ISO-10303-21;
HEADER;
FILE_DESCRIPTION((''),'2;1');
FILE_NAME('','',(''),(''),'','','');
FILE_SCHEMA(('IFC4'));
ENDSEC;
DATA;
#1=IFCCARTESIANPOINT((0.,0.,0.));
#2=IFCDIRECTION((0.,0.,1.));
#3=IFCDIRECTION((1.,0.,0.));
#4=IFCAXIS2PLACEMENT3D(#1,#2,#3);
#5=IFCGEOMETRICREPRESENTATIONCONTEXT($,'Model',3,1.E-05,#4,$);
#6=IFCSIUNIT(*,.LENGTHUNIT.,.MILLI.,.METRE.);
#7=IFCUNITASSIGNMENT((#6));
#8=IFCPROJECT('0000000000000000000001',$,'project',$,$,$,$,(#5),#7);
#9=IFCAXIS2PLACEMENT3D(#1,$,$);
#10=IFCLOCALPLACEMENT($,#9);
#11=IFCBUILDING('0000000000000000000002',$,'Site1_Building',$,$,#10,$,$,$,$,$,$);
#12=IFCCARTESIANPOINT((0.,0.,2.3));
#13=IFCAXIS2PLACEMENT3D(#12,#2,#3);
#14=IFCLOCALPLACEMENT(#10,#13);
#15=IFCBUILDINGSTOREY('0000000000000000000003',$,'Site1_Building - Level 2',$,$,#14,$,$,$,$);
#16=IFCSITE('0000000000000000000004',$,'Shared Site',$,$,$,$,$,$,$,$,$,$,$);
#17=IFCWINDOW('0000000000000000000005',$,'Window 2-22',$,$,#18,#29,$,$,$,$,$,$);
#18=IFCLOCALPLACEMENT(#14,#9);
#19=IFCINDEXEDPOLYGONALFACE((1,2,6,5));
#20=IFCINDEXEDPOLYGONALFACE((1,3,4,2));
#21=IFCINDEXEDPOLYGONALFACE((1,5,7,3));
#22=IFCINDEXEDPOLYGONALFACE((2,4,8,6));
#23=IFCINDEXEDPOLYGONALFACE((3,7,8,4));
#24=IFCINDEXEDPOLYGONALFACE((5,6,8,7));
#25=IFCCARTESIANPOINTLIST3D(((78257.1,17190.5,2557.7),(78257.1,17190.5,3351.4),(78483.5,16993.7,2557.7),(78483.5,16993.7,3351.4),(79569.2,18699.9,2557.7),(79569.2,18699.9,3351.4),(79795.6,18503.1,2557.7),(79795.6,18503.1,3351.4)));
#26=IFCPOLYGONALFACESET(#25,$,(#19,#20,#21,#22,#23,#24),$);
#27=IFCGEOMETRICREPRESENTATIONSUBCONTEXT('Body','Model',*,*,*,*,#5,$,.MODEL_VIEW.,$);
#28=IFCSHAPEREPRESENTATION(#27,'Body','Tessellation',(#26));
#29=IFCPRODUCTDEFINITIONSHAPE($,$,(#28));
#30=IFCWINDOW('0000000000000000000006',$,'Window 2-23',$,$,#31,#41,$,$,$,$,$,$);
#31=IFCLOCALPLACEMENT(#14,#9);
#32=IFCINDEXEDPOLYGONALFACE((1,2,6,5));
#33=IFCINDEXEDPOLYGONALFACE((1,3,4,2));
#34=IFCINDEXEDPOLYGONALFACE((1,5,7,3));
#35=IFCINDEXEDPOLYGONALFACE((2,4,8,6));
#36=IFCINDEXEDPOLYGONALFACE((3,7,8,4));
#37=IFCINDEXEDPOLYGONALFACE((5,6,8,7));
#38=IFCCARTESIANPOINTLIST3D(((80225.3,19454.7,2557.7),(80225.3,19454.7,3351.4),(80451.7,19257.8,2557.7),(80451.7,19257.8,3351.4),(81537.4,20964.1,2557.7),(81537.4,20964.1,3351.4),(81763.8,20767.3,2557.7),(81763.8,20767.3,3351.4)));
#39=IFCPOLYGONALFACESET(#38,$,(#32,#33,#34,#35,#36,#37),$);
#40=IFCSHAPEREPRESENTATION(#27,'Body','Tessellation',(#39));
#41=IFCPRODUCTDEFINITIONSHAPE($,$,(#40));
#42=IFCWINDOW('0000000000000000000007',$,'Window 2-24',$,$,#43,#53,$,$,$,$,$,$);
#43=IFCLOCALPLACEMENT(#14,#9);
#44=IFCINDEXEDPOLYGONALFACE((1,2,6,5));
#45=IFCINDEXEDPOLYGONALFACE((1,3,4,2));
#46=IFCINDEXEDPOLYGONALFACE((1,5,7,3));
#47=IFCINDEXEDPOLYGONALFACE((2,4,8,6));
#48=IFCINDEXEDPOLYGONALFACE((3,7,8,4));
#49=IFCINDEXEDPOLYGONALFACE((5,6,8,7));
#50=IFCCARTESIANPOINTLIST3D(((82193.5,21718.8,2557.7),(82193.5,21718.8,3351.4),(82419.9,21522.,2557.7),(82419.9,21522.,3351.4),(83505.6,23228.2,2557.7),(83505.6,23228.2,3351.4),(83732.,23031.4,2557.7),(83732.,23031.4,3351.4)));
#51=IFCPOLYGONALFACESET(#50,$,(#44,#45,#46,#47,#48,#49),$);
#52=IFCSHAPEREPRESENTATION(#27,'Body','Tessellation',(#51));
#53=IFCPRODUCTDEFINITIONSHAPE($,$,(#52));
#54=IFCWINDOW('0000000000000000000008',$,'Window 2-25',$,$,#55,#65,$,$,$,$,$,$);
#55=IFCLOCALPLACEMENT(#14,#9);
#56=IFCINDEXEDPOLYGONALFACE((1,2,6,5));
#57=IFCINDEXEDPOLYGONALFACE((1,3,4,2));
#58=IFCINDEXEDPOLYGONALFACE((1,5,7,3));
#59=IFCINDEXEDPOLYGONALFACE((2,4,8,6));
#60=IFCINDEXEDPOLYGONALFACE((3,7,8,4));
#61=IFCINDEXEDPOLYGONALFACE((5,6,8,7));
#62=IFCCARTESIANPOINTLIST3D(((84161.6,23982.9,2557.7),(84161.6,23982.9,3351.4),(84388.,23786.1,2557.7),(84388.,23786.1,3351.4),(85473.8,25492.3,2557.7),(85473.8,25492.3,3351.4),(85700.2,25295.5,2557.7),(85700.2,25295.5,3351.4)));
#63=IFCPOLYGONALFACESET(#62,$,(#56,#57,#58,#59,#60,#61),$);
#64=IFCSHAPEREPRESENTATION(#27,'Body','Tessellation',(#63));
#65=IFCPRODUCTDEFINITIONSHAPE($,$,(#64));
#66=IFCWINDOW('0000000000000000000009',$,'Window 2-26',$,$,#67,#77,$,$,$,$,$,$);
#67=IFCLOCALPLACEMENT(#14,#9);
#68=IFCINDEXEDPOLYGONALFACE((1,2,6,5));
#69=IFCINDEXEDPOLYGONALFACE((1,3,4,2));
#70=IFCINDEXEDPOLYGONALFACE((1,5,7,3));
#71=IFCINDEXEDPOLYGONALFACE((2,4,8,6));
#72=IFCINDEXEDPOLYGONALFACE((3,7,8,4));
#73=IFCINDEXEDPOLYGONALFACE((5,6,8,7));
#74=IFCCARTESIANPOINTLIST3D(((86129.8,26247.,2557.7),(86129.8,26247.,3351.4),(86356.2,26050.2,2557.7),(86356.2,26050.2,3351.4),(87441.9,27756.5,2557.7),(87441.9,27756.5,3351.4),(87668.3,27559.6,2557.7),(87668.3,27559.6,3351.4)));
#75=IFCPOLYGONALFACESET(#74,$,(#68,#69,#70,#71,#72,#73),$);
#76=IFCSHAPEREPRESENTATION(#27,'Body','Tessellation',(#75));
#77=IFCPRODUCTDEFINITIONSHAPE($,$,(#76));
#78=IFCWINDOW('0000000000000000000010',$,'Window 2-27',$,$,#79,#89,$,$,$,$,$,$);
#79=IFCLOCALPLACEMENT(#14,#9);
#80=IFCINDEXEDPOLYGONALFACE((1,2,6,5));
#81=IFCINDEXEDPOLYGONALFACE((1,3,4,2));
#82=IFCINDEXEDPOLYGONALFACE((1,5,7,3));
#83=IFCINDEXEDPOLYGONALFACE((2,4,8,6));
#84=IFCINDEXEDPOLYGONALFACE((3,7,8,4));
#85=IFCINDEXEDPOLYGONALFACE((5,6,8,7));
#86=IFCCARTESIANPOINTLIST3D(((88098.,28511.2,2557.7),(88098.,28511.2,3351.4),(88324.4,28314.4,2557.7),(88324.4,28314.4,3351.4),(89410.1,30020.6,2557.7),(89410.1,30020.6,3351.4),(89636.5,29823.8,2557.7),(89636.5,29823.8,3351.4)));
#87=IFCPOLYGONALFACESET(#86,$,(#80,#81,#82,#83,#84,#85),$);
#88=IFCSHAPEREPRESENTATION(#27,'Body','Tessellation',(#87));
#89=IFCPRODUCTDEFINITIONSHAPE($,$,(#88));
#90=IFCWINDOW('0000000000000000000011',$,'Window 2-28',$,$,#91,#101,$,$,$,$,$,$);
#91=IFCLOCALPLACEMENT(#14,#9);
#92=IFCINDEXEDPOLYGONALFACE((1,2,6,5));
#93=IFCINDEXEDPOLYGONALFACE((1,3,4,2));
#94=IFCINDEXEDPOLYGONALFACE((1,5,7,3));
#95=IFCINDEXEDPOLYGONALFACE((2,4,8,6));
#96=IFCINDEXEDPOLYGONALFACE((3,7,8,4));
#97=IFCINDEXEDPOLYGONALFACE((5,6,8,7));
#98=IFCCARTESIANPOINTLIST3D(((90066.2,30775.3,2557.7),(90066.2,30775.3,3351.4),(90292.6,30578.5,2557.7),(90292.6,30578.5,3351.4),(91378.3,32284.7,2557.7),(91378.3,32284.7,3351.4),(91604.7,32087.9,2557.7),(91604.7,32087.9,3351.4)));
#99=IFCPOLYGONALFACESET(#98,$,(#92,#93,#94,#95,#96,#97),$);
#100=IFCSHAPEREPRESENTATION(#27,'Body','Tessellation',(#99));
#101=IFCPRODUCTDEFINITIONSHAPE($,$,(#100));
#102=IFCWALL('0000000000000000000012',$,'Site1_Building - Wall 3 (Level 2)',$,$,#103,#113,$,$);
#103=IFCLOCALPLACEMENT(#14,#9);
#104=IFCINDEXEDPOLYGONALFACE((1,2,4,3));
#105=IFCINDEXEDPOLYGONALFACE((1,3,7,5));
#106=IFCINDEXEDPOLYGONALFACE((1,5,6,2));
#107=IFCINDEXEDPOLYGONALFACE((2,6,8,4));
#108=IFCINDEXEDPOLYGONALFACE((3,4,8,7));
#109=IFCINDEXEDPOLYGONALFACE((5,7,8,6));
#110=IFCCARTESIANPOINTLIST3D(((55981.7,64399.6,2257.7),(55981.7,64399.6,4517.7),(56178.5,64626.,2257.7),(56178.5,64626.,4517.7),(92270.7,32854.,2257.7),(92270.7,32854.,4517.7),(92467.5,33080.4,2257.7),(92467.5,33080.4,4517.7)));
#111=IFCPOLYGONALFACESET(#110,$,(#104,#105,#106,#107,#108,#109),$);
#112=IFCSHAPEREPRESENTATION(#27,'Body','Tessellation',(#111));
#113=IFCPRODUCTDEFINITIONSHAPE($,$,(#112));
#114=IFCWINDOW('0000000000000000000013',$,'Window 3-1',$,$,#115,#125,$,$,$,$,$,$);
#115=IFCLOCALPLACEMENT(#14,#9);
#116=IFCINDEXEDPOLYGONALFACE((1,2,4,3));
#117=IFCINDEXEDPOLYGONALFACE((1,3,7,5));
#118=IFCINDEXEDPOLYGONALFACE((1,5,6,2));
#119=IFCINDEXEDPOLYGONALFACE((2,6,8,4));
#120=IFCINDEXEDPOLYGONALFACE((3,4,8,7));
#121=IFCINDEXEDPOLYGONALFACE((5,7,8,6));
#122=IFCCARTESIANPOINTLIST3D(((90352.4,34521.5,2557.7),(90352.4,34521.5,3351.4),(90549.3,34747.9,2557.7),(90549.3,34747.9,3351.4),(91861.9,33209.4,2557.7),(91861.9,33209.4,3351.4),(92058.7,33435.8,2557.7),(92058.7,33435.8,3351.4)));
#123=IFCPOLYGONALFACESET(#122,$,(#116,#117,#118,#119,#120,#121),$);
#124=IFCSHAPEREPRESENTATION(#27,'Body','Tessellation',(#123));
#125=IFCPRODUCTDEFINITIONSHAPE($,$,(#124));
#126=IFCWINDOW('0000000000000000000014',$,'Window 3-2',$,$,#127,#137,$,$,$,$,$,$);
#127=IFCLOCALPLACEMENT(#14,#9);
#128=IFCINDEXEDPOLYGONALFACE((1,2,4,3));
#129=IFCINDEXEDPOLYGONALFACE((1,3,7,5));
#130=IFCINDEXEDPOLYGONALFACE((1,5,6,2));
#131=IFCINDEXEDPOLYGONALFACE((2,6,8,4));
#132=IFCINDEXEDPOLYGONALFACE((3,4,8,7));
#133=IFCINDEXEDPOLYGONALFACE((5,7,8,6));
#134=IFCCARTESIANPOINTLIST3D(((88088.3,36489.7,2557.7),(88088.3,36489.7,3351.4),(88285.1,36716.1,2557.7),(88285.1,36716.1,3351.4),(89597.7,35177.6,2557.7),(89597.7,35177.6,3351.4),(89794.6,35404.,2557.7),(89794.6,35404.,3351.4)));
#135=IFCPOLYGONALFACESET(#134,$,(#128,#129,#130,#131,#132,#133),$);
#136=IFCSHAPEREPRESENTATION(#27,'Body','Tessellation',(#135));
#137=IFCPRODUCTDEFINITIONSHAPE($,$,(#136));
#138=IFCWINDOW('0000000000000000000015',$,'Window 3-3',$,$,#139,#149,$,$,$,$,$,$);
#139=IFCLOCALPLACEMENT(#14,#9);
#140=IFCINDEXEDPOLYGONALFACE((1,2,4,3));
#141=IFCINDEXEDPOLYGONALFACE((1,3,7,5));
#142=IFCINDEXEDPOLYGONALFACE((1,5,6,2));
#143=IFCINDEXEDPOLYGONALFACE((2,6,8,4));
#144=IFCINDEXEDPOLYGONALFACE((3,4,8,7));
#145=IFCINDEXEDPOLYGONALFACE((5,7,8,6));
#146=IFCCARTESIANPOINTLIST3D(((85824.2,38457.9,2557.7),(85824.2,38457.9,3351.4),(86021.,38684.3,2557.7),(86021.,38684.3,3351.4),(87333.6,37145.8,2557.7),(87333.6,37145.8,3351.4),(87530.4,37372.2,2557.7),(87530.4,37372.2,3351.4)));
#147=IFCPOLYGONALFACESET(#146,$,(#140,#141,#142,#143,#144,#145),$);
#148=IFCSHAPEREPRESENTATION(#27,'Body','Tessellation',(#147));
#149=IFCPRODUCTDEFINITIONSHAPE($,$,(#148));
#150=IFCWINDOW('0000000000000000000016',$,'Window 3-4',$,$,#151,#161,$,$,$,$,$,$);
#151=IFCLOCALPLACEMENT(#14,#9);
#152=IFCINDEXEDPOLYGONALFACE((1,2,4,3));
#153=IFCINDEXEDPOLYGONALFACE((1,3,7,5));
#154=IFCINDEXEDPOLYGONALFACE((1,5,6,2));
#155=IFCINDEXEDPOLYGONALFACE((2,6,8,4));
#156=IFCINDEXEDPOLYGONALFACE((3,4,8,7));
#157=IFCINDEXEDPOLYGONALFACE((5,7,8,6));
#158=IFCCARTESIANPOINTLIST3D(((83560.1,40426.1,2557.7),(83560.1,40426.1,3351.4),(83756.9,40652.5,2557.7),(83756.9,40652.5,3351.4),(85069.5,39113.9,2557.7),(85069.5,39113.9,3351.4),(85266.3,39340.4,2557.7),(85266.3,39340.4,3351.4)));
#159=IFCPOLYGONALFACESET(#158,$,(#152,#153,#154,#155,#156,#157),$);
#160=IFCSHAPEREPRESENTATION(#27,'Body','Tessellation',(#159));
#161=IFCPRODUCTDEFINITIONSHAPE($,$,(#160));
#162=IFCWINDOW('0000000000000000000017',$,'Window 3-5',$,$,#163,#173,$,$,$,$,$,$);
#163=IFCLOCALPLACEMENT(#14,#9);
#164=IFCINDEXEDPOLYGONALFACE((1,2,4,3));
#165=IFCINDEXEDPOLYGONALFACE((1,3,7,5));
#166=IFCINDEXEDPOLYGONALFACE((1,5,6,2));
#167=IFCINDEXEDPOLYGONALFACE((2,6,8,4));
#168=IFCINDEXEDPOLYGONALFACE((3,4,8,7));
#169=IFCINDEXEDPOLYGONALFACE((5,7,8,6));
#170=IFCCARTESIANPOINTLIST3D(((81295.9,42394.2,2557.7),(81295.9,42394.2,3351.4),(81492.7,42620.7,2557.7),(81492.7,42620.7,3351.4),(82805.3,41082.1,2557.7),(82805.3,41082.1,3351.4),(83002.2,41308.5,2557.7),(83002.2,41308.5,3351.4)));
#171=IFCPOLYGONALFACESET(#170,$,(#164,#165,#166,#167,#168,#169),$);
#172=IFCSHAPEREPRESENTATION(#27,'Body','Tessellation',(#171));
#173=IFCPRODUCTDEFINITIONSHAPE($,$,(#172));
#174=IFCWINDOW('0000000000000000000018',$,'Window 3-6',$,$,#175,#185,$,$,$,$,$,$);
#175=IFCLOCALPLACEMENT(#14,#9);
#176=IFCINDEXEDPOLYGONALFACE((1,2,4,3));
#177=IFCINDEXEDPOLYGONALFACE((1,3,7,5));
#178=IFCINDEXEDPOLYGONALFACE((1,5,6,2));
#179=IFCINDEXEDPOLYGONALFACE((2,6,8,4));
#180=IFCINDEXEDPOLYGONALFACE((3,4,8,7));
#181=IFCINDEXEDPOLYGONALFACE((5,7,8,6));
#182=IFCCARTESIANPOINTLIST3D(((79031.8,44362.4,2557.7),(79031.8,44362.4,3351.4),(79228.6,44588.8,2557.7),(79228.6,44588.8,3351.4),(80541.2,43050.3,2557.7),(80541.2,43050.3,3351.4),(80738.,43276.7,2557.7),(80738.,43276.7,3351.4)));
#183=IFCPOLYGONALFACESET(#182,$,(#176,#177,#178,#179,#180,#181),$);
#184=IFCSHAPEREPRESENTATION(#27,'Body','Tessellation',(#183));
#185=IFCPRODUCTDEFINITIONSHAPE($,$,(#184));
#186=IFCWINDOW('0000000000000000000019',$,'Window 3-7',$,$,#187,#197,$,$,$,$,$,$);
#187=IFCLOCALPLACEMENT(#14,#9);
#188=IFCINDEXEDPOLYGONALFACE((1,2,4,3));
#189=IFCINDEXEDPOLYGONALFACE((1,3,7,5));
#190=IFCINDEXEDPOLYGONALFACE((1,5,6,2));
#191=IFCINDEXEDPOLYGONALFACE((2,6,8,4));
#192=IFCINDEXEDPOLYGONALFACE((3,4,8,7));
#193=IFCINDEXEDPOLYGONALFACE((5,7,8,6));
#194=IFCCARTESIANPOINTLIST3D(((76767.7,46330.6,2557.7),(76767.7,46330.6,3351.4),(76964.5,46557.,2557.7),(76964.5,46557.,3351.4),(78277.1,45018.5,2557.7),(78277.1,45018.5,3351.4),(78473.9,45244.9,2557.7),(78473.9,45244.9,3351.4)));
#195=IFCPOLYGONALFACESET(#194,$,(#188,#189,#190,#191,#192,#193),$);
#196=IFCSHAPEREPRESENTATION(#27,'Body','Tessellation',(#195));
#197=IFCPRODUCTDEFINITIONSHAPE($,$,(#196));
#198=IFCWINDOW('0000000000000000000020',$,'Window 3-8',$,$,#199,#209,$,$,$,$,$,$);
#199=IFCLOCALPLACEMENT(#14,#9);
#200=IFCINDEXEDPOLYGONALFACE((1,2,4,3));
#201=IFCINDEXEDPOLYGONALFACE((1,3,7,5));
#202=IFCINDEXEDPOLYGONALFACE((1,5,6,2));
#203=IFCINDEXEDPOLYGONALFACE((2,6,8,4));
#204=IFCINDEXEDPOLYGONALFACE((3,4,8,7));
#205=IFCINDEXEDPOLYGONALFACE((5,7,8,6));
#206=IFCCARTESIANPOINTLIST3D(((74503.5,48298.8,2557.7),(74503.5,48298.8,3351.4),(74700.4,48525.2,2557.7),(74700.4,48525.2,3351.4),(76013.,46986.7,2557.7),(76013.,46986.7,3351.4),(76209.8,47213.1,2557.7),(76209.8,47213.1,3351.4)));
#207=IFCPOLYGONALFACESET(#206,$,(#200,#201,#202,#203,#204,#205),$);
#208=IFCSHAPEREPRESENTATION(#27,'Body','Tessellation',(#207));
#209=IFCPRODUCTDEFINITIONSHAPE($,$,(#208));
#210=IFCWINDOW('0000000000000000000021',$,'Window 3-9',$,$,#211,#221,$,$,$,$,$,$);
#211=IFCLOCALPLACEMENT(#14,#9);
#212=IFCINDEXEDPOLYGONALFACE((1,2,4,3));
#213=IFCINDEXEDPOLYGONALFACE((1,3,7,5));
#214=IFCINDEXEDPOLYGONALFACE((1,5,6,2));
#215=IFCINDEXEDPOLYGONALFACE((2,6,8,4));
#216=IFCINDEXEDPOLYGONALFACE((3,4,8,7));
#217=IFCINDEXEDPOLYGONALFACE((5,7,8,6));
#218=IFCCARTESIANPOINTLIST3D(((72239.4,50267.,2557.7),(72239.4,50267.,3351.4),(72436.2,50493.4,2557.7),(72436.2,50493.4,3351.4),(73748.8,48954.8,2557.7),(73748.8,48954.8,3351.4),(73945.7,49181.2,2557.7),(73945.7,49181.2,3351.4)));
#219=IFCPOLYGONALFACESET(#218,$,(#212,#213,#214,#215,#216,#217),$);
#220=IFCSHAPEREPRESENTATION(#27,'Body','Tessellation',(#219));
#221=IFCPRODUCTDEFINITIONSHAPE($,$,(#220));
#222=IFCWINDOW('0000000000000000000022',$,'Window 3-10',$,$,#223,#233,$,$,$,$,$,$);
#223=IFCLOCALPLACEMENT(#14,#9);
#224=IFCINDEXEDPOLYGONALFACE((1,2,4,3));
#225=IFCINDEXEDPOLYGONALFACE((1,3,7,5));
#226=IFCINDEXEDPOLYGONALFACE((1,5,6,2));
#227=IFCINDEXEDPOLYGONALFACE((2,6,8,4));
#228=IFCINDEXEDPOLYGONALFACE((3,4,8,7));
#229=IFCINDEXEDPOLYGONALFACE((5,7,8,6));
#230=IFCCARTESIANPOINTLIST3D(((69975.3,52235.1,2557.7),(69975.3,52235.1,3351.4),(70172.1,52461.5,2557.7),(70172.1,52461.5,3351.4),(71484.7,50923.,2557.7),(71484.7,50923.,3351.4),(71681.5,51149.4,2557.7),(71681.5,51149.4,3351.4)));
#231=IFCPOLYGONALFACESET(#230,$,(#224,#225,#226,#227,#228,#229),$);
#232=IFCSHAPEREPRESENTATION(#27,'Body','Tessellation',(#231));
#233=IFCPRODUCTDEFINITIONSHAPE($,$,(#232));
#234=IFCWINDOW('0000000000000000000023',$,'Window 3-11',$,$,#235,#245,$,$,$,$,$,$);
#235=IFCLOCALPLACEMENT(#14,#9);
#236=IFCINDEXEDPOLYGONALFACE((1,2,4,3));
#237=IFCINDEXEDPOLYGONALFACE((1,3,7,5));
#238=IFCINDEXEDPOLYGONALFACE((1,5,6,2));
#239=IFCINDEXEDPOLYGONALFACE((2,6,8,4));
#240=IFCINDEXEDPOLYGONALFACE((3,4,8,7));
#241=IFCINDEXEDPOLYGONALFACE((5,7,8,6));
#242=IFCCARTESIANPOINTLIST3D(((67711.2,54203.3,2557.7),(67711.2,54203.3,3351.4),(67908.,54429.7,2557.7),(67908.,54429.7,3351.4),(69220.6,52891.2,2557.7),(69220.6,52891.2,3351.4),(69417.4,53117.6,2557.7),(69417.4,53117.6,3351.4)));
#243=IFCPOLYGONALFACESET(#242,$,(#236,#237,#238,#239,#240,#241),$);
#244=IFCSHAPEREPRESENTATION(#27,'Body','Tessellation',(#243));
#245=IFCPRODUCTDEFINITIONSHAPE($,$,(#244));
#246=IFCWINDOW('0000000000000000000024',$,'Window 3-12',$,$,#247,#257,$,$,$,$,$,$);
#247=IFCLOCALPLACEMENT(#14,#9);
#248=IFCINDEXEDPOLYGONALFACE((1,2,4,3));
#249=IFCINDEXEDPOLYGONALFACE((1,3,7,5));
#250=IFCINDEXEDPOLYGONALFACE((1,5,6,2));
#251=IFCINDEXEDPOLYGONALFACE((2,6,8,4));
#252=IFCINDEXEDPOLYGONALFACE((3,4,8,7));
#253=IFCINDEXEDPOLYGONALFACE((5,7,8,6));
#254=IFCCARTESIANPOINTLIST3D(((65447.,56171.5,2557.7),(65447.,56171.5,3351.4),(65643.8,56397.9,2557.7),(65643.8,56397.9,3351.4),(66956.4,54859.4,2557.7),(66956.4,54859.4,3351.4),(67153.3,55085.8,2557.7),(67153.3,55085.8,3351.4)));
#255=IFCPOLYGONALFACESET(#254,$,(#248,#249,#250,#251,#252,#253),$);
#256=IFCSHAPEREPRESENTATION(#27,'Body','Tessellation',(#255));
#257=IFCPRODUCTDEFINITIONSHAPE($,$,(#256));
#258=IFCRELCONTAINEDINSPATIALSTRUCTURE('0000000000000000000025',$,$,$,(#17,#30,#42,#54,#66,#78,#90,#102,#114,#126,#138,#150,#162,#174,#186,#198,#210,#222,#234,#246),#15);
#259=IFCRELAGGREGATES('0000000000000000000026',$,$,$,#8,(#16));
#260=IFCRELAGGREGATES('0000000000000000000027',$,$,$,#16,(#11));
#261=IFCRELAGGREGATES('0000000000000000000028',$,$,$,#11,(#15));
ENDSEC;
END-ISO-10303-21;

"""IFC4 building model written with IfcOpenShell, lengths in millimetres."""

from ifc_helpers import new_model, si_unit, frame, origin, origin_with_axes, place, context, subcontext, project, spatial, indexed_curve, outline, extrude, element, save


model = new_model("IFC4")

# Units and contexts
model_context = context("Model", 3, precision=1e-05, world=origin_with_axes())
body_context = subcontext(model_context, "Body", "Model", "MODEL_VIEW")
ifc_project = project(units=[si_unit("LENGTHUNIT", "METRE", prefix="MILLI")], contexts=[model_context])

# Site, building, storey
site = spatial("IfcSite", under=ifc_project, Name="Shared Site")
building_placement = place(None, origin())
building = spatial("IfcBuilding", under=site, at=building_placement, Name="Site1_Building")
storey_placement = place(building_placement, frame((0.0, 0.0, 2.3), z_axis=(0.0, 0.0, 1.0), x_axis=(1.0, 0.0, 0.0)))
storey = spatial("IfcBuildingStorey", under=building, at=storey_placement, Name="Site1_Building - Level 2")

# Windows
for number, where, z_axis, x_axis, name in (
    (1, (78483.5, 16993.7, 2557.7), (0.0, 0.0, 1.0), (0.656059, 0.75471, 0.0), "Window 2-22"),
    (2, (80451.7, 19257.8, 2557.7), (0.0, 0.0, 1.0), (0.656059, 0.75471, 0.0), "Window 2-23"),
    (3, (82419.9, 21522.0, 2557.7), (0.0, 0.0, 1.0), (0.656059, 0.75471, 0.0), "Window 2-24"),
    (4, (84388.0, 23786.1, 2557.7), (0.0, 0.0, 1.0), (0.656059, 0.75471, 0.0), "Window 2-25"),
    (5, (86356.2, 26050.2, 2557.7), (0.0, 0.0, 1.0), (0.656059, 0.75471, 0.0), "Window 2-26"),
    (6, (88324.4, 28314.4, 2557.7), (0.0, 0.0, 1.0), (0.656059, 0.75471, 0.0), "Window 2-27"),
    (7, (90292.6, 30578.5, 2557.7), (0.0, 0.0, 1.0), (0.656059, 0.75471, 0.0), "Window 2-28"),
):
    element("IfcWindow", number, at=place(storey_placement, frame(where, z_axis=z_axis, x_axis=x_axis)), inside=storey, Name=name, context=body_context, shape_type="SweptSolid", body=[
        extrude(outline(indexed_curve([(0.0, 0.0), (0.0, 300.0), (2000.0, 300.0), (2000.0, 0.0), (0.0, 0.0)], self_intersect=False)), origin_with_axes(), (0.0, 0.0, 1.0), 793.6),
    ])

# Wall
wall_placement = place(storey_placement, frame((92467.5, 33080.4, 2257.7), z_axis=(0.0, 0.0, 1.0), x_axis=(-0.75471, 0.656059, 0.0)))
element("IfcWall", 8, at=wall_placement, inside=storey, Name="Site1_Building - Wall 3 (Level 2)", context=body_context, shape_type="SweptSolid", body=[
    extrude(outline(indexed_curve([(0.0, 0.0), (0.0, 300.0), (48083.4, 300.0), (48083.4, 0.0), (0.0, 0.0)], self_intersect=False)), origin_with_axes(), (0.0, 0.0, 1.0), 2260.0),
])

# Windows
for number, where, z_axis, x_axis, name in (
    (9, (92058.7, 33435.8, 2557.7), (0.0, 0.0, 1.0), (-0.75471, 0.656059, 0.0), "Window 3-1"),
    (10, (89794.6, 35404.0, 2557.7), (0.0, 0.0, 1.0), (-0.75471, 0.656059, 0.0), "Window 3-2"),
    (11, (87530.4, 37372.2, 2557.7), (0.0, 0.0, 1.0), (-0.75471, 0.656059, 0.0), "Window 3-3"),
    (12, (85266.3, 39340.4, 2557.7), (0.0, 0.0, 1.0), (-0.75471, 0.656059, 0.0), "Window 3-4"),
    (13, (83002.2, 41308.5, 2557.7), (0.0, 0.0, 1.0), (-0.75471, 0.656059, 0.0), "Window 3-5"),
    (14, (80738.0, 43276.7, 2557.7), (0.0, 0.0, 1.0), (-0.75471, 0.656059, 0.0), "Window 3-6"),
    (15, (78473.9, 45244.9, 2557.7), (0.0, 0.0, 1.0), (-0.75471, 0.656059, 0.0), "Window 3-7"),
    (16, (76209.8, 47213.1, 2557.7), (0.0, 0.0, 1.0), (-0.75471, 0.656059, 0.0), "Window 3-8"),
    (17, (73945.7, 49181.2, 2557.7), (0.0, 0.0, 1.0), (-0.75471, 0.656059, 0.0), "Window 3-9"),
    (18, (71681.5, 51149.4, 2557.7), (0.0, 0.0, 1.0), (-0.75471, 0.656059, 0.0), "Window 3-10"),
    (19, (69417.4, 53117.6, 2557.7), (0.0, 0.0, 1.0), (-0.75471, 0.656059, 0.0), "Window 3-11"),
    (20, (67153.3, 55085.8, 2557.7), (0.0, 0.0, 1.0), (-0.75471, 0.656059, 0.0), "Window 3-12"),
):
    element("IfcWindow", number, at=place(storey_placement, frame(where, z_axis=z_axis, x_axis=x_axis)), inside=storey, Name=name, context=body_context, shape_type="SweptSolid", body=[
        extrude(outline(indexed_curve([(0.0, 0.0), (0.0, 300.0), (2000.0, 300.0), (2000.0, 0.0), (0.0, 0.0)], self_intersect=False)), origin_with_axes(), (0.0, 0.0, 1.0), 793.6),
    ])

save(model, "model.ifc")
